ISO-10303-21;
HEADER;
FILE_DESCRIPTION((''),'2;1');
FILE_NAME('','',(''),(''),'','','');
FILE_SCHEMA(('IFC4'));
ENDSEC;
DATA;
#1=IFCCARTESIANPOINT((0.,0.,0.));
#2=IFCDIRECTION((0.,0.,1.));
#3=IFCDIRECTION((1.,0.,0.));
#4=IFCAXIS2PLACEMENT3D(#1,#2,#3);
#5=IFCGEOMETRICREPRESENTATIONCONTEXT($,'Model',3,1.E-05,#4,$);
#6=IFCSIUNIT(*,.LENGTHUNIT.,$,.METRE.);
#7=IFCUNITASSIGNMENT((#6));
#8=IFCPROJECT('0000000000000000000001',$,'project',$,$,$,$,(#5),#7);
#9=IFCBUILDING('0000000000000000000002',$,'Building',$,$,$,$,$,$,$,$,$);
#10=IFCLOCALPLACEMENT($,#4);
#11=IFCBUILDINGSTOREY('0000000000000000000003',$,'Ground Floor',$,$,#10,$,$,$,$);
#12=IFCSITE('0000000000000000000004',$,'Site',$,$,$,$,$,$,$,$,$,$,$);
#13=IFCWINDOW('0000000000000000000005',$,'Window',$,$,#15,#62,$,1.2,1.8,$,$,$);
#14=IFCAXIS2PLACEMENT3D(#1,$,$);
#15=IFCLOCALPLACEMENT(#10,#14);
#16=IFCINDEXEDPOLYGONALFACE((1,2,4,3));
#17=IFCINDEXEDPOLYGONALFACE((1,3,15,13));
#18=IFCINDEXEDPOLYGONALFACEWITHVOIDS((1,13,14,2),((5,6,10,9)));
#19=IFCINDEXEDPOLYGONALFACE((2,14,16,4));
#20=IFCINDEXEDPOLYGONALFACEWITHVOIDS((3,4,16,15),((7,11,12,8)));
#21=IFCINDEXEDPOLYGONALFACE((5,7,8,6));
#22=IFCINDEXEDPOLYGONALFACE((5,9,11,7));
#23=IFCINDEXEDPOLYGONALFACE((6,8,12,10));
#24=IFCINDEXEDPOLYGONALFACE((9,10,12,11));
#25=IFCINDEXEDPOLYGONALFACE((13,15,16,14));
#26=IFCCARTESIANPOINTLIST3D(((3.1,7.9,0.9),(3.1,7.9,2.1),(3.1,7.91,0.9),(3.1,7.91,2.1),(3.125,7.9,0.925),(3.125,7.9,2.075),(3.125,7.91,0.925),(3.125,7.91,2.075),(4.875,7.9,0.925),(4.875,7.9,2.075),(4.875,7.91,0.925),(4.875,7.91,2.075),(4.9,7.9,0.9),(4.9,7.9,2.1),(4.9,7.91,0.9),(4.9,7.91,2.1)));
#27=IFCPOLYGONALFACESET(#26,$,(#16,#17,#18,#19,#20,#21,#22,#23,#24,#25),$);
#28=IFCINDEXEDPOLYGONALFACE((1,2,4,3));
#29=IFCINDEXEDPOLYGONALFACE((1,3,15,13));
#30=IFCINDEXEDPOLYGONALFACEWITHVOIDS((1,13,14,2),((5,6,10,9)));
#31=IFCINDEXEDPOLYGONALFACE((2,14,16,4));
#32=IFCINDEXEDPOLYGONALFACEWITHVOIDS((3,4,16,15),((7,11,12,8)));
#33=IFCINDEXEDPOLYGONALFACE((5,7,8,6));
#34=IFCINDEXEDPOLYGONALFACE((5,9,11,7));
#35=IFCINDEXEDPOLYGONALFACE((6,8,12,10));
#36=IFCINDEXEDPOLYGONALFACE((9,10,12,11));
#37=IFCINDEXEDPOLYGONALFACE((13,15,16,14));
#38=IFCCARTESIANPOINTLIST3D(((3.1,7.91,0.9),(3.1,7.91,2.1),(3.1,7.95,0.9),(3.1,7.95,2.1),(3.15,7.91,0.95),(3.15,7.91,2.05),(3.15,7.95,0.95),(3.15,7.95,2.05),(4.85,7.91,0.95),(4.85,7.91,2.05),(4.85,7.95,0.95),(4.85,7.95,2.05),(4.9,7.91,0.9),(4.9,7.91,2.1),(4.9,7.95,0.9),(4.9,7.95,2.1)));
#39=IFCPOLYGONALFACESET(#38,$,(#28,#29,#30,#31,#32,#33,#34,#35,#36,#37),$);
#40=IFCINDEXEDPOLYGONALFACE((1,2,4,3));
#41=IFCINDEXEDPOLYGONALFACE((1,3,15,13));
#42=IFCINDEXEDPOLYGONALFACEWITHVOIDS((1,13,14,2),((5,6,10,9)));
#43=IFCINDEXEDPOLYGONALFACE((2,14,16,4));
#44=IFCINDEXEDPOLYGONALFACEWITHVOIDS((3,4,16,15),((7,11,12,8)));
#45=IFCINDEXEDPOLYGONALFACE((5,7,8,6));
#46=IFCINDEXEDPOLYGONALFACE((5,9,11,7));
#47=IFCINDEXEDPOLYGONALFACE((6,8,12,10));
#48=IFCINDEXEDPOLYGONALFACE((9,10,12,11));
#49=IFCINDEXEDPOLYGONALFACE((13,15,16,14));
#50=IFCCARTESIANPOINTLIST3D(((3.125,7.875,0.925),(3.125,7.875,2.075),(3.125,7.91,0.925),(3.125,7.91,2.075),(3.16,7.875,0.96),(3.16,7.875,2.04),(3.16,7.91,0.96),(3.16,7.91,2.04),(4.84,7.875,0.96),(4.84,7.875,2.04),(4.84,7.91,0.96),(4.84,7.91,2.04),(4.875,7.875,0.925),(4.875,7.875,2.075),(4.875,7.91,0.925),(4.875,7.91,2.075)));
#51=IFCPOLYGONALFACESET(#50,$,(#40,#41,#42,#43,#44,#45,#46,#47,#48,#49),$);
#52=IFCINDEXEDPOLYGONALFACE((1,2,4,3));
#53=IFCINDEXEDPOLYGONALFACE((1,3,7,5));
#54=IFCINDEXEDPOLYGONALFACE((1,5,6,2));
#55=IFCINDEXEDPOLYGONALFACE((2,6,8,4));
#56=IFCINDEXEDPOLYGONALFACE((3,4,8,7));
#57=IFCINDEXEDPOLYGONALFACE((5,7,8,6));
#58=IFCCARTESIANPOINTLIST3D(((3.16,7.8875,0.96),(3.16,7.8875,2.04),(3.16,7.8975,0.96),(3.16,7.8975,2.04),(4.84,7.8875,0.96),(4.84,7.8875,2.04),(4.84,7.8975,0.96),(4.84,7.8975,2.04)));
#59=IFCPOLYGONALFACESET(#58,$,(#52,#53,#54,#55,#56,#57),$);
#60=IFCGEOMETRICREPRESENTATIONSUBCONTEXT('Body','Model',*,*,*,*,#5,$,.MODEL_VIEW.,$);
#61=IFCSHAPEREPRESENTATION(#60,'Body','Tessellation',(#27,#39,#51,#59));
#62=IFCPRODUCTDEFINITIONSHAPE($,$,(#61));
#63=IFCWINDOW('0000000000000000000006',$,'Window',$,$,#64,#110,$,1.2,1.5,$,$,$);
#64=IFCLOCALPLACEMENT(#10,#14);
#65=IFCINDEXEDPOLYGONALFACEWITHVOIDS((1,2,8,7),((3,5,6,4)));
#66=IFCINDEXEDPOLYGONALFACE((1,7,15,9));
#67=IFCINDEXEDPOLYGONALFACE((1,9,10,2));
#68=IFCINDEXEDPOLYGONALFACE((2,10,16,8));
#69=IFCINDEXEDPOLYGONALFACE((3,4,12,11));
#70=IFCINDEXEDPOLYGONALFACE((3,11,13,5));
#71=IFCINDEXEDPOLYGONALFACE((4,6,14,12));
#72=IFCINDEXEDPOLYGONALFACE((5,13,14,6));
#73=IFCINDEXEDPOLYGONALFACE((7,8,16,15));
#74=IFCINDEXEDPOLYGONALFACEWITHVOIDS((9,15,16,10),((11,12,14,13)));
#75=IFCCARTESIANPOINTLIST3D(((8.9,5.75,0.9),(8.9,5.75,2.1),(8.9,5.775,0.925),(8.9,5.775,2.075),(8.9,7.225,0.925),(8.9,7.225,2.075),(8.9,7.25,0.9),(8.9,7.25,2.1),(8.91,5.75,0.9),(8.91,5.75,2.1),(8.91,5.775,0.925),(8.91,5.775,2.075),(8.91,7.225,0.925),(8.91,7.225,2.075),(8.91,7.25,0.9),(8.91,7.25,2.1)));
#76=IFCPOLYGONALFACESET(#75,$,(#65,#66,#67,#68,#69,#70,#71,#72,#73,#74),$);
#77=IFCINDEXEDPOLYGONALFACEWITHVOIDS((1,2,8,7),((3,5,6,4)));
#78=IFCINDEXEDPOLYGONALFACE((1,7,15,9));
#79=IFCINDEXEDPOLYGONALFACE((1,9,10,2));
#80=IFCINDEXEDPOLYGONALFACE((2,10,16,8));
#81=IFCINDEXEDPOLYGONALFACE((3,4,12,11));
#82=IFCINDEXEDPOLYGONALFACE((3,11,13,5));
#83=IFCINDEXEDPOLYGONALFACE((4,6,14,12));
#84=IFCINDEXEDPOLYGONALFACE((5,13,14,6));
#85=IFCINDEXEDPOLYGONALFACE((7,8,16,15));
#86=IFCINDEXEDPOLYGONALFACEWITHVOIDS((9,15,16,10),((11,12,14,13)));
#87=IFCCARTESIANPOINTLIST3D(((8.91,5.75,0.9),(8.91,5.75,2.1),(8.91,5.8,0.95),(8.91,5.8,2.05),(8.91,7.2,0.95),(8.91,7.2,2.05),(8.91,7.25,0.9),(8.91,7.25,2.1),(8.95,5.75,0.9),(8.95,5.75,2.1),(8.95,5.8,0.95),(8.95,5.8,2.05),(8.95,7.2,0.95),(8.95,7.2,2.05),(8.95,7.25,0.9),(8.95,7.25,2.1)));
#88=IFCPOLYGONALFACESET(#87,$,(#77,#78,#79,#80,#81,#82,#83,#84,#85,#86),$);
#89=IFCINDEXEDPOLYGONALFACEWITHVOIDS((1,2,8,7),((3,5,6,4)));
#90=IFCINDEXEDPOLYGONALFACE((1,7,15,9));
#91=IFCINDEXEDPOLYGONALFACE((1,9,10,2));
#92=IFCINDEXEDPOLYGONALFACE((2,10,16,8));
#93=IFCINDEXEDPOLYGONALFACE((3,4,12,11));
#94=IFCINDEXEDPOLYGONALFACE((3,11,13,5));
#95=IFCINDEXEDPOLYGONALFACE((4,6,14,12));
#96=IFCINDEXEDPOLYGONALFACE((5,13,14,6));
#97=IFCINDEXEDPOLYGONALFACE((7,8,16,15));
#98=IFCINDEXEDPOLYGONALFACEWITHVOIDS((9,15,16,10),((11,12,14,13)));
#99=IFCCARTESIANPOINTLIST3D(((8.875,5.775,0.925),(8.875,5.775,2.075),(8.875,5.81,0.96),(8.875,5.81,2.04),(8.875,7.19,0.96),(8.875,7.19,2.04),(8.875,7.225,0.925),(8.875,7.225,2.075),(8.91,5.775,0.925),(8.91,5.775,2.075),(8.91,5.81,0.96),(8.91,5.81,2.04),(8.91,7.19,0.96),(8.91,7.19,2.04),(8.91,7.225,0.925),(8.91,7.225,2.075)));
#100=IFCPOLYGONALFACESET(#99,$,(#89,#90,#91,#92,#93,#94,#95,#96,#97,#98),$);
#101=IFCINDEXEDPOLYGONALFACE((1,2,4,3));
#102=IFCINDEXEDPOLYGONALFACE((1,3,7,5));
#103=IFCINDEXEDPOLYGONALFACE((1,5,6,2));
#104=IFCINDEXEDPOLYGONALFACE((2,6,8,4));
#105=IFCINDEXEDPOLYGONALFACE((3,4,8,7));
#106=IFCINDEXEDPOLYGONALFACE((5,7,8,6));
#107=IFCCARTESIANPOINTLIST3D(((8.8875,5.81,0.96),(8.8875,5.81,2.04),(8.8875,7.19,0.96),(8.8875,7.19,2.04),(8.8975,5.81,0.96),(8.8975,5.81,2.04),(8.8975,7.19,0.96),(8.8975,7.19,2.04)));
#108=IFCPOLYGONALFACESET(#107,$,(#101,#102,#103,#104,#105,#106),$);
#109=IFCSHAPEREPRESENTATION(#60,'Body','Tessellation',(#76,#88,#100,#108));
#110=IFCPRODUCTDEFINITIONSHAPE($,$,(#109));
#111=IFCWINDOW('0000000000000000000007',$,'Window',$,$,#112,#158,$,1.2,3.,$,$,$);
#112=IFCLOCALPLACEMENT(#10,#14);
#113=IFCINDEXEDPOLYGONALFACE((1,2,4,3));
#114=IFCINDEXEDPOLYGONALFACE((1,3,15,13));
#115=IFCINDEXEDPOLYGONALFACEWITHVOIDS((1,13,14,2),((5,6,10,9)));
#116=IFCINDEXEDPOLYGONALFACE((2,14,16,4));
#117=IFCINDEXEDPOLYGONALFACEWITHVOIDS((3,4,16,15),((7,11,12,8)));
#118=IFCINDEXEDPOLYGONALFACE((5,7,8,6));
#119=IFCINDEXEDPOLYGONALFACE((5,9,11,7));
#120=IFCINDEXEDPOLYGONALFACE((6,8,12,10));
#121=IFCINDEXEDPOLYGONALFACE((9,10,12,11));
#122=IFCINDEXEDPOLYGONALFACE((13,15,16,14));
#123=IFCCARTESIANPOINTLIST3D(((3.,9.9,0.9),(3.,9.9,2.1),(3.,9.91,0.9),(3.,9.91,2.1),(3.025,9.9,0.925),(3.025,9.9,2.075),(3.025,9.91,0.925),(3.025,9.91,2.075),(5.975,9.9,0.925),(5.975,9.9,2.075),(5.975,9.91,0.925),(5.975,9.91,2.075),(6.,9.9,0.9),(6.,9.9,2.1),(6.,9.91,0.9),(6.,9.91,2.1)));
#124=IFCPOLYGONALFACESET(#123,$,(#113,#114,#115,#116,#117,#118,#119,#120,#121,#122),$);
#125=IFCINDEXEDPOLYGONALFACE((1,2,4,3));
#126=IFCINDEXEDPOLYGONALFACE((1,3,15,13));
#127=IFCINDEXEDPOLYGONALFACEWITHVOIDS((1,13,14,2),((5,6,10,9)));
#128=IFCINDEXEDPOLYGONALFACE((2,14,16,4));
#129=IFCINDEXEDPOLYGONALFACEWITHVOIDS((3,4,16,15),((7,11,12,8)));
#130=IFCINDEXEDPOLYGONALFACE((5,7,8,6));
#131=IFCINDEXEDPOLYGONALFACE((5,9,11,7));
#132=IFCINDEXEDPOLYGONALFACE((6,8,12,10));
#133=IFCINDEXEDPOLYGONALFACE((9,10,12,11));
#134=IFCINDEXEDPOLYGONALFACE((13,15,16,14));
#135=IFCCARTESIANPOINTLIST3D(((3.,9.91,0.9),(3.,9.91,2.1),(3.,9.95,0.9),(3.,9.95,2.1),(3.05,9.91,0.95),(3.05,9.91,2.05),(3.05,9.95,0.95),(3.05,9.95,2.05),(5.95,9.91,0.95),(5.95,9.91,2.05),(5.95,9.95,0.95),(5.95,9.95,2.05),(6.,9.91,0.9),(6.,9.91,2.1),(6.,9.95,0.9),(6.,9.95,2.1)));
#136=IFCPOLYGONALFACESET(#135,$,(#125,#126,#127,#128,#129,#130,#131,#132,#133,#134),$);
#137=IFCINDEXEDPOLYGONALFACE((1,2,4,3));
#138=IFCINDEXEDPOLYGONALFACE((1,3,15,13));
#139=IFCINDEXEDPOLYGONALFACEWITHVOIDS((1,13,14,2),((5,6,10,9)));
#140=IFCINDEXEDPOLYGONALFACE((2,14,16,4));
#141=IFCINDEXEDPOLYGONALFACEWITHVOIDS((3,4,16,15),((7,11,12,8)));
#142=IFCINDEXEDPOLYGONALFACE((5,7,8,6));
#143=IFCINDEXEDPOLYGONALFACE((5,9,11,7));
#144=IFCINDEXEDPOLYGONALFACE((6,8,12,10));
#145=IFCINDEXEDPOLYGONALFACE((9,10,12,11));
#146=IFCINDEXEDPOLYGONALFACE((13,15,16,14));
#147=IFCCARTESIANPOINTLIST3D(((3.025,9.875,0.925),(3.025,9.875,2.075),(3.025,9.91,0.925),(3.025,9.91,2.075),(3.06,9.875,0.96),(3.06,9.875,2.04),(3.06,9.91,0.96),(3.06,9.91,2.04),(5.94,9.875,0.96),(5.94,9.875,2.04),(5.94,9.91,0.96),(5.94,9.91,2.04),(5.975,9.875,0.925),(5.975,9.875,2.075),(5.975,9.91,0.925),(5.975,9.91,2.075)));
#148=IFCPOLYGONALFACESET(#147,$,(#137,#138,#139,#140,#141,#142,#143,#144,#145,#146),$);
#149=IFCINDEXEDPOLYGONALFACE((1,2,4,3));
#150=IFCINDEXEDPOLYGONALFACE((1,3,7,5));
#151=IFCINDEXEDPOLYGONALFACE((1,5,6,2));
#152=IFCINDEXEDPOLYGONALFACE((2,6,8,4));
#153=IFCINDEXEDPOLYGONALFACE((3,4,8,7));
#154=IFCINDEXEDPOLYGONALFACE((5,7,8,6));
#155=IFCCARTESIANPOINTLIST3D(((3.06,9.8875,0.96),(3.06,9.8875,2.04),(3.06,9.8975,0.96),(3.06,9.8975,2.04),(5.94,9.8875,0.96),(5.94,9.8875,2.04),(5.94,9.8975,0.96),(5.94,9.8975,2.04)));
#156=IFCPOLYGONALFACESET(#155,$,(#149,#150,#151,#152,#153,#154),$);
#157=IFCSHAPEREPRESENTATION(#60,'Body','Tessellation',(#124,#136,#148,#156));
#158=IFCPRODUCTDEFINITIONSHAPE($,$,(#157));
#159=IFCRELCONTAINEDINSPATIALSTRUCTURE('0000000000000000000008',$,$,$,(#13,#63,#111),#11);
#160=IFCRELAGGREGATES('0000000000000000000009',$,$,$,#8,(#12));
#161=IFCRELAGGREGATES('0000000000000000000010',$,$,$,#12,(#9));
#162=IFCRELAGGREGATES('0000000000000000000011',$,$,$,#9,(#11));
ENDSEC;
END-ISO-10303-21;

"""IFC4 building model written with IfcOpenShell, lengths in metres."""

from ifc_helpers import new_model, si_unit, frame, origin_with_axes, place, context, subcontext, project, spatial, line, indexed_curve, outline, extrude, element, save


model = new_model("IFC4")

# Units and contexts
model_context = context("Model", 3, precision=1e-05, world=origin_with_axes())
body_context = subcontext(model_context, "Body", "Model", "MODEL_VIEW")
ifc_project = project(units=[si_unit("LENGTHUNIT", "METRE")], contexts=[model_context])

# Site, building, storey
site = spatial("IfcSite", under=ifc_project, Name="Site")
building = spatial("IfcBuilding", under=site, Name="Building")
storey_placement = place(None, origin_with_axes())
storey = spatial("IfcBuildingStorey", under=building, at=storey_placement, Name="Ground Floor")

# Windows
window_1_placement = place(storey_placement, frame((4.9, 8.0, 0.9), z_axis=(0.0, 0.0, 1.0), x_axis=(-1.0, 0.0, 0.0)))
element("IfcWindow", 1, at=window_1_placement, inside=storey, Name="Window", OverallHeight=1.2, OverallWidth=1.8, context=body_context, shape_type="SweptSolid", body=[
    extrude(outline(indexed_curve([(0.0, 0.0), (1.8, 0.0), (1.8, 1.2), (0.0, 1.2)], segments=[line(1, 2, 3, 4, 1)]), holes=[indexed_curve([(0.025, 0.025), (1.775, 0.025), (1.775, 1.175), (0.025, 1.175)], segments=[line(1, 2, 3, 4, 1)])]), frame((0.0, 0.09, 0.0), z_axis=(0.0, -1.0, 0.0), x_axis=(1.0, 0.0, 0.0)), (0.0, 0.0, -1.0), 0.01),
    extrude(outline(indexed_curve([(0.0, 0.0), (1.8, 0.0), (1.8, 1.2), (0.0, 1.2)], segments=[line(1, 2, 3, 4, 1)]), holes=[indexed_curve([(0.05, 0.05), (1.75, 0.05), (1.75, 1.15), (0.05, 1.15)], segments=[line(1, 2, 3, 4, 1)])]), frame((0.0, 0.05, 0.0), z_axis=(0.0, -1.0, 0.0), x_axis=(1.0, 0.0, 0.0)), (0.0, 0.0, -1.0), 0.04),
    extrude(outline(indexed_curve([(0.0, 0.0), (1.75, 0.0), (1.75, 1.15), (0.0, 1.15)], segments=[line(1, 2, 3, 4, 1)]), holes=[indexed_curve([(0.035, 0.035), (1.715, 0.035), (1.715, 1.115), (0.035, 1.115)], segments=[line(1, 2, 3, 4, 1)])]), frame((0.025, 0.09, 0.025), z_axis=(0.0, -1.0, 0.0), x_axis=(1.0, 0.0, 0.0)), (0.0, 0.0, -1.0), 0.035),
    extrude(outline(indexed_curve([(0.035, 0.035), (1.715, 0.035), (1.715, 1.115), (0.035, 1.115)], segments=[line(1, 2, 3, 4, 1)])), frame((0.025, 0.1025, 0.025), z_axis=(0.0, -1.0, 0.0), x_axis=(1.0, 0.0, 0.0)), (0.0, 0.0, -1.0), 0.01),
])
window_2_placement = place(storey_placement, frame((9.0, 5.75, 0.9), z_axis=(0.0, 0.0, 1.0), x_axis=(0.0, 1.0, 0.0)))
element("IfcWindow", 2, at=window_2_placement, inside=storey, Name="Window", OverallHeight=1.2, OverallWidth=1.5, context=body_context, shape_type="SweptSolid", body=[
    extrude(outline(indexed_curve([(0.0, 0.0), (1.5, 0.0), (1.5, 1.2), (0.0, 1.2)], segments=[line(1, 2, 3, 4, 1)]), holes=[indexed_curve([(0.025, 0.025), (1.475, 0.025), (1.475, 1.175), (0.025, 1.175)], segments=[line(1, 2, 3, 4, 1)])]), frame((0.0, 0.09, 0.0), z_axis=(0.0, -1.0, 0.0), x_axis=(1.0, 0.0, 0.0)), (0.0, 0.0, -1.0), 0.01),
    extrude(outline(indexed_curve([(0.0, 0.0), (1.5, 0.0), (1.5, 1.2), (0.0, 1.2)], segments=[line(1, 2, 3, 4, 1)]), holes=[indexed_curve([(0.05, 0.05), (1.45, 0.05), (1.45, 1.15), (0.05, 1.15)], segments=[line(1, 2, 3, 4, 1)])]), frame((0.0, 0.05, 0.0), z_axis=(0.0, -1.0, 0.0), x_axis=(1.0, 0.0, 0.0)), (0.0, 0.0, -1.0), 0.04),
    extrude(outline(indexed_curve([(0.0, 0.0), (1.45, 0.0), (1.45, 1.15), (0.0, 1.15)], segments=[line(1, 2, 3, 4, 1)]), holes=[indexed_curve([(0.035, 0.035), (1.415, 0.035), (1.415, 1.115), (0.035, 1.115)], segments=[line(1, 2, 3, 4, 1)])]), frame((0.025, 0.09, 0.025), z_axis=(0.0, -1.0, 0.0), x_axis=(1.0, 0.0, 0.0)), (0.0, 0.0, -1.0), 0.035),
    extrude(outline(indexed_curve([(0.035, 0.035), (1.415, 0.035), (1.415, 1.115), (0.035, 1.115)], segments=[line(1, 2, 3, 4, 1)])), frame((0.025, 0.1025, 0.025), z_axis=(0.0, -1.0, 0.0), x_axis=(1.0, 0.0, 0.0)), (0.0, 0.0, -1.0), 0.01),
])
window_3_placement = place(storey_placement, frame((6.0, 10.0, 0.9), z_axis=(0.0, 0.0, 1.0), x_axis=(-1.0, 0.0, 0.0)))
element("IfcWindow", 3, at=window_3_placement, inside=storey, Name="Window", OverallHeight=1.2, OverallWidth=3.0, context=body_context, shape_type="SweptSolid", body=[
    extrude(outline(indexed_curve([(0.0, 0.0), (3.0, 0.0), (3.0, 1.2), (0.0, 1.2)], segments=[line(1, 2, 3, 4, 1)]), holes=[indexed_curve([(0.025, 0.025), (2.975, 0.025), (2.975, 1.175), (0.025, 1.175)], segments=[line(1, 2, 3, 4, 1)])]), frame((0.0, 0.09, 0.0), z_axis=(0.0, -1.0, 0.0), x_axis=(1.0, 0.0, 0.0)), (0.0, 0.0, -1.0), 0.01),
    extrude(outline(indexed_curve([(0.0, 0.0), (3.0, 0.0), (3.0, 1.2), (0.0, 1.2)], segments=[line(1, 2, 3, 4, 1)]), holes=[indexed_curve([(0.05, 0.05), (2.95, 0.05), (2.95, 1.15), (0.05, 1.15)], segments=[line(1, 2, 3, 4, 1)])]), frame((0.0, 0.05, 0.0), z_axis=(0.0, -1.0, 0.0), x_axis=(1.0, 0.0, 0.0)), (0.0, 0.0, -1.0), 0.04),
    extrude(outline(indexed_curve([(0.0, 0.0), (2.95, 0.0), (2.95, 1.15), (0.0, 1.15)], segments=[line(1, 2, 3, 4, 1)]), holes=[indexed_curve([(0.035, 0.035), (2.915, 0.035), (2.915, 1.115), (0.035, 1.115)], segments=[line(1, 2, 3, 4, 1)])]), frame((0.025, 0.09, 0.025), z_axis=(0.0, -1.0, 0.0), x_axis=(1.0, 0.0, 0.0)), (0.0, 0.0, -1.0), 0.035),
    extrude(outline(indexed_curve([(0.035, 0.035), (2.915, 0.035), (2.915, 1.115), (0.035, 1.115)], segments=[line(1, 2, 3, 4, 1)])), frame((0.025, 0.1025, 0.025), z_axis=(0.0, -1.0, 0.0), x_axis=(1.0, 0.0, 0.0)), (0.0, 0.0, -1.0), 0.01),
])

save(model, "model.ifc")
